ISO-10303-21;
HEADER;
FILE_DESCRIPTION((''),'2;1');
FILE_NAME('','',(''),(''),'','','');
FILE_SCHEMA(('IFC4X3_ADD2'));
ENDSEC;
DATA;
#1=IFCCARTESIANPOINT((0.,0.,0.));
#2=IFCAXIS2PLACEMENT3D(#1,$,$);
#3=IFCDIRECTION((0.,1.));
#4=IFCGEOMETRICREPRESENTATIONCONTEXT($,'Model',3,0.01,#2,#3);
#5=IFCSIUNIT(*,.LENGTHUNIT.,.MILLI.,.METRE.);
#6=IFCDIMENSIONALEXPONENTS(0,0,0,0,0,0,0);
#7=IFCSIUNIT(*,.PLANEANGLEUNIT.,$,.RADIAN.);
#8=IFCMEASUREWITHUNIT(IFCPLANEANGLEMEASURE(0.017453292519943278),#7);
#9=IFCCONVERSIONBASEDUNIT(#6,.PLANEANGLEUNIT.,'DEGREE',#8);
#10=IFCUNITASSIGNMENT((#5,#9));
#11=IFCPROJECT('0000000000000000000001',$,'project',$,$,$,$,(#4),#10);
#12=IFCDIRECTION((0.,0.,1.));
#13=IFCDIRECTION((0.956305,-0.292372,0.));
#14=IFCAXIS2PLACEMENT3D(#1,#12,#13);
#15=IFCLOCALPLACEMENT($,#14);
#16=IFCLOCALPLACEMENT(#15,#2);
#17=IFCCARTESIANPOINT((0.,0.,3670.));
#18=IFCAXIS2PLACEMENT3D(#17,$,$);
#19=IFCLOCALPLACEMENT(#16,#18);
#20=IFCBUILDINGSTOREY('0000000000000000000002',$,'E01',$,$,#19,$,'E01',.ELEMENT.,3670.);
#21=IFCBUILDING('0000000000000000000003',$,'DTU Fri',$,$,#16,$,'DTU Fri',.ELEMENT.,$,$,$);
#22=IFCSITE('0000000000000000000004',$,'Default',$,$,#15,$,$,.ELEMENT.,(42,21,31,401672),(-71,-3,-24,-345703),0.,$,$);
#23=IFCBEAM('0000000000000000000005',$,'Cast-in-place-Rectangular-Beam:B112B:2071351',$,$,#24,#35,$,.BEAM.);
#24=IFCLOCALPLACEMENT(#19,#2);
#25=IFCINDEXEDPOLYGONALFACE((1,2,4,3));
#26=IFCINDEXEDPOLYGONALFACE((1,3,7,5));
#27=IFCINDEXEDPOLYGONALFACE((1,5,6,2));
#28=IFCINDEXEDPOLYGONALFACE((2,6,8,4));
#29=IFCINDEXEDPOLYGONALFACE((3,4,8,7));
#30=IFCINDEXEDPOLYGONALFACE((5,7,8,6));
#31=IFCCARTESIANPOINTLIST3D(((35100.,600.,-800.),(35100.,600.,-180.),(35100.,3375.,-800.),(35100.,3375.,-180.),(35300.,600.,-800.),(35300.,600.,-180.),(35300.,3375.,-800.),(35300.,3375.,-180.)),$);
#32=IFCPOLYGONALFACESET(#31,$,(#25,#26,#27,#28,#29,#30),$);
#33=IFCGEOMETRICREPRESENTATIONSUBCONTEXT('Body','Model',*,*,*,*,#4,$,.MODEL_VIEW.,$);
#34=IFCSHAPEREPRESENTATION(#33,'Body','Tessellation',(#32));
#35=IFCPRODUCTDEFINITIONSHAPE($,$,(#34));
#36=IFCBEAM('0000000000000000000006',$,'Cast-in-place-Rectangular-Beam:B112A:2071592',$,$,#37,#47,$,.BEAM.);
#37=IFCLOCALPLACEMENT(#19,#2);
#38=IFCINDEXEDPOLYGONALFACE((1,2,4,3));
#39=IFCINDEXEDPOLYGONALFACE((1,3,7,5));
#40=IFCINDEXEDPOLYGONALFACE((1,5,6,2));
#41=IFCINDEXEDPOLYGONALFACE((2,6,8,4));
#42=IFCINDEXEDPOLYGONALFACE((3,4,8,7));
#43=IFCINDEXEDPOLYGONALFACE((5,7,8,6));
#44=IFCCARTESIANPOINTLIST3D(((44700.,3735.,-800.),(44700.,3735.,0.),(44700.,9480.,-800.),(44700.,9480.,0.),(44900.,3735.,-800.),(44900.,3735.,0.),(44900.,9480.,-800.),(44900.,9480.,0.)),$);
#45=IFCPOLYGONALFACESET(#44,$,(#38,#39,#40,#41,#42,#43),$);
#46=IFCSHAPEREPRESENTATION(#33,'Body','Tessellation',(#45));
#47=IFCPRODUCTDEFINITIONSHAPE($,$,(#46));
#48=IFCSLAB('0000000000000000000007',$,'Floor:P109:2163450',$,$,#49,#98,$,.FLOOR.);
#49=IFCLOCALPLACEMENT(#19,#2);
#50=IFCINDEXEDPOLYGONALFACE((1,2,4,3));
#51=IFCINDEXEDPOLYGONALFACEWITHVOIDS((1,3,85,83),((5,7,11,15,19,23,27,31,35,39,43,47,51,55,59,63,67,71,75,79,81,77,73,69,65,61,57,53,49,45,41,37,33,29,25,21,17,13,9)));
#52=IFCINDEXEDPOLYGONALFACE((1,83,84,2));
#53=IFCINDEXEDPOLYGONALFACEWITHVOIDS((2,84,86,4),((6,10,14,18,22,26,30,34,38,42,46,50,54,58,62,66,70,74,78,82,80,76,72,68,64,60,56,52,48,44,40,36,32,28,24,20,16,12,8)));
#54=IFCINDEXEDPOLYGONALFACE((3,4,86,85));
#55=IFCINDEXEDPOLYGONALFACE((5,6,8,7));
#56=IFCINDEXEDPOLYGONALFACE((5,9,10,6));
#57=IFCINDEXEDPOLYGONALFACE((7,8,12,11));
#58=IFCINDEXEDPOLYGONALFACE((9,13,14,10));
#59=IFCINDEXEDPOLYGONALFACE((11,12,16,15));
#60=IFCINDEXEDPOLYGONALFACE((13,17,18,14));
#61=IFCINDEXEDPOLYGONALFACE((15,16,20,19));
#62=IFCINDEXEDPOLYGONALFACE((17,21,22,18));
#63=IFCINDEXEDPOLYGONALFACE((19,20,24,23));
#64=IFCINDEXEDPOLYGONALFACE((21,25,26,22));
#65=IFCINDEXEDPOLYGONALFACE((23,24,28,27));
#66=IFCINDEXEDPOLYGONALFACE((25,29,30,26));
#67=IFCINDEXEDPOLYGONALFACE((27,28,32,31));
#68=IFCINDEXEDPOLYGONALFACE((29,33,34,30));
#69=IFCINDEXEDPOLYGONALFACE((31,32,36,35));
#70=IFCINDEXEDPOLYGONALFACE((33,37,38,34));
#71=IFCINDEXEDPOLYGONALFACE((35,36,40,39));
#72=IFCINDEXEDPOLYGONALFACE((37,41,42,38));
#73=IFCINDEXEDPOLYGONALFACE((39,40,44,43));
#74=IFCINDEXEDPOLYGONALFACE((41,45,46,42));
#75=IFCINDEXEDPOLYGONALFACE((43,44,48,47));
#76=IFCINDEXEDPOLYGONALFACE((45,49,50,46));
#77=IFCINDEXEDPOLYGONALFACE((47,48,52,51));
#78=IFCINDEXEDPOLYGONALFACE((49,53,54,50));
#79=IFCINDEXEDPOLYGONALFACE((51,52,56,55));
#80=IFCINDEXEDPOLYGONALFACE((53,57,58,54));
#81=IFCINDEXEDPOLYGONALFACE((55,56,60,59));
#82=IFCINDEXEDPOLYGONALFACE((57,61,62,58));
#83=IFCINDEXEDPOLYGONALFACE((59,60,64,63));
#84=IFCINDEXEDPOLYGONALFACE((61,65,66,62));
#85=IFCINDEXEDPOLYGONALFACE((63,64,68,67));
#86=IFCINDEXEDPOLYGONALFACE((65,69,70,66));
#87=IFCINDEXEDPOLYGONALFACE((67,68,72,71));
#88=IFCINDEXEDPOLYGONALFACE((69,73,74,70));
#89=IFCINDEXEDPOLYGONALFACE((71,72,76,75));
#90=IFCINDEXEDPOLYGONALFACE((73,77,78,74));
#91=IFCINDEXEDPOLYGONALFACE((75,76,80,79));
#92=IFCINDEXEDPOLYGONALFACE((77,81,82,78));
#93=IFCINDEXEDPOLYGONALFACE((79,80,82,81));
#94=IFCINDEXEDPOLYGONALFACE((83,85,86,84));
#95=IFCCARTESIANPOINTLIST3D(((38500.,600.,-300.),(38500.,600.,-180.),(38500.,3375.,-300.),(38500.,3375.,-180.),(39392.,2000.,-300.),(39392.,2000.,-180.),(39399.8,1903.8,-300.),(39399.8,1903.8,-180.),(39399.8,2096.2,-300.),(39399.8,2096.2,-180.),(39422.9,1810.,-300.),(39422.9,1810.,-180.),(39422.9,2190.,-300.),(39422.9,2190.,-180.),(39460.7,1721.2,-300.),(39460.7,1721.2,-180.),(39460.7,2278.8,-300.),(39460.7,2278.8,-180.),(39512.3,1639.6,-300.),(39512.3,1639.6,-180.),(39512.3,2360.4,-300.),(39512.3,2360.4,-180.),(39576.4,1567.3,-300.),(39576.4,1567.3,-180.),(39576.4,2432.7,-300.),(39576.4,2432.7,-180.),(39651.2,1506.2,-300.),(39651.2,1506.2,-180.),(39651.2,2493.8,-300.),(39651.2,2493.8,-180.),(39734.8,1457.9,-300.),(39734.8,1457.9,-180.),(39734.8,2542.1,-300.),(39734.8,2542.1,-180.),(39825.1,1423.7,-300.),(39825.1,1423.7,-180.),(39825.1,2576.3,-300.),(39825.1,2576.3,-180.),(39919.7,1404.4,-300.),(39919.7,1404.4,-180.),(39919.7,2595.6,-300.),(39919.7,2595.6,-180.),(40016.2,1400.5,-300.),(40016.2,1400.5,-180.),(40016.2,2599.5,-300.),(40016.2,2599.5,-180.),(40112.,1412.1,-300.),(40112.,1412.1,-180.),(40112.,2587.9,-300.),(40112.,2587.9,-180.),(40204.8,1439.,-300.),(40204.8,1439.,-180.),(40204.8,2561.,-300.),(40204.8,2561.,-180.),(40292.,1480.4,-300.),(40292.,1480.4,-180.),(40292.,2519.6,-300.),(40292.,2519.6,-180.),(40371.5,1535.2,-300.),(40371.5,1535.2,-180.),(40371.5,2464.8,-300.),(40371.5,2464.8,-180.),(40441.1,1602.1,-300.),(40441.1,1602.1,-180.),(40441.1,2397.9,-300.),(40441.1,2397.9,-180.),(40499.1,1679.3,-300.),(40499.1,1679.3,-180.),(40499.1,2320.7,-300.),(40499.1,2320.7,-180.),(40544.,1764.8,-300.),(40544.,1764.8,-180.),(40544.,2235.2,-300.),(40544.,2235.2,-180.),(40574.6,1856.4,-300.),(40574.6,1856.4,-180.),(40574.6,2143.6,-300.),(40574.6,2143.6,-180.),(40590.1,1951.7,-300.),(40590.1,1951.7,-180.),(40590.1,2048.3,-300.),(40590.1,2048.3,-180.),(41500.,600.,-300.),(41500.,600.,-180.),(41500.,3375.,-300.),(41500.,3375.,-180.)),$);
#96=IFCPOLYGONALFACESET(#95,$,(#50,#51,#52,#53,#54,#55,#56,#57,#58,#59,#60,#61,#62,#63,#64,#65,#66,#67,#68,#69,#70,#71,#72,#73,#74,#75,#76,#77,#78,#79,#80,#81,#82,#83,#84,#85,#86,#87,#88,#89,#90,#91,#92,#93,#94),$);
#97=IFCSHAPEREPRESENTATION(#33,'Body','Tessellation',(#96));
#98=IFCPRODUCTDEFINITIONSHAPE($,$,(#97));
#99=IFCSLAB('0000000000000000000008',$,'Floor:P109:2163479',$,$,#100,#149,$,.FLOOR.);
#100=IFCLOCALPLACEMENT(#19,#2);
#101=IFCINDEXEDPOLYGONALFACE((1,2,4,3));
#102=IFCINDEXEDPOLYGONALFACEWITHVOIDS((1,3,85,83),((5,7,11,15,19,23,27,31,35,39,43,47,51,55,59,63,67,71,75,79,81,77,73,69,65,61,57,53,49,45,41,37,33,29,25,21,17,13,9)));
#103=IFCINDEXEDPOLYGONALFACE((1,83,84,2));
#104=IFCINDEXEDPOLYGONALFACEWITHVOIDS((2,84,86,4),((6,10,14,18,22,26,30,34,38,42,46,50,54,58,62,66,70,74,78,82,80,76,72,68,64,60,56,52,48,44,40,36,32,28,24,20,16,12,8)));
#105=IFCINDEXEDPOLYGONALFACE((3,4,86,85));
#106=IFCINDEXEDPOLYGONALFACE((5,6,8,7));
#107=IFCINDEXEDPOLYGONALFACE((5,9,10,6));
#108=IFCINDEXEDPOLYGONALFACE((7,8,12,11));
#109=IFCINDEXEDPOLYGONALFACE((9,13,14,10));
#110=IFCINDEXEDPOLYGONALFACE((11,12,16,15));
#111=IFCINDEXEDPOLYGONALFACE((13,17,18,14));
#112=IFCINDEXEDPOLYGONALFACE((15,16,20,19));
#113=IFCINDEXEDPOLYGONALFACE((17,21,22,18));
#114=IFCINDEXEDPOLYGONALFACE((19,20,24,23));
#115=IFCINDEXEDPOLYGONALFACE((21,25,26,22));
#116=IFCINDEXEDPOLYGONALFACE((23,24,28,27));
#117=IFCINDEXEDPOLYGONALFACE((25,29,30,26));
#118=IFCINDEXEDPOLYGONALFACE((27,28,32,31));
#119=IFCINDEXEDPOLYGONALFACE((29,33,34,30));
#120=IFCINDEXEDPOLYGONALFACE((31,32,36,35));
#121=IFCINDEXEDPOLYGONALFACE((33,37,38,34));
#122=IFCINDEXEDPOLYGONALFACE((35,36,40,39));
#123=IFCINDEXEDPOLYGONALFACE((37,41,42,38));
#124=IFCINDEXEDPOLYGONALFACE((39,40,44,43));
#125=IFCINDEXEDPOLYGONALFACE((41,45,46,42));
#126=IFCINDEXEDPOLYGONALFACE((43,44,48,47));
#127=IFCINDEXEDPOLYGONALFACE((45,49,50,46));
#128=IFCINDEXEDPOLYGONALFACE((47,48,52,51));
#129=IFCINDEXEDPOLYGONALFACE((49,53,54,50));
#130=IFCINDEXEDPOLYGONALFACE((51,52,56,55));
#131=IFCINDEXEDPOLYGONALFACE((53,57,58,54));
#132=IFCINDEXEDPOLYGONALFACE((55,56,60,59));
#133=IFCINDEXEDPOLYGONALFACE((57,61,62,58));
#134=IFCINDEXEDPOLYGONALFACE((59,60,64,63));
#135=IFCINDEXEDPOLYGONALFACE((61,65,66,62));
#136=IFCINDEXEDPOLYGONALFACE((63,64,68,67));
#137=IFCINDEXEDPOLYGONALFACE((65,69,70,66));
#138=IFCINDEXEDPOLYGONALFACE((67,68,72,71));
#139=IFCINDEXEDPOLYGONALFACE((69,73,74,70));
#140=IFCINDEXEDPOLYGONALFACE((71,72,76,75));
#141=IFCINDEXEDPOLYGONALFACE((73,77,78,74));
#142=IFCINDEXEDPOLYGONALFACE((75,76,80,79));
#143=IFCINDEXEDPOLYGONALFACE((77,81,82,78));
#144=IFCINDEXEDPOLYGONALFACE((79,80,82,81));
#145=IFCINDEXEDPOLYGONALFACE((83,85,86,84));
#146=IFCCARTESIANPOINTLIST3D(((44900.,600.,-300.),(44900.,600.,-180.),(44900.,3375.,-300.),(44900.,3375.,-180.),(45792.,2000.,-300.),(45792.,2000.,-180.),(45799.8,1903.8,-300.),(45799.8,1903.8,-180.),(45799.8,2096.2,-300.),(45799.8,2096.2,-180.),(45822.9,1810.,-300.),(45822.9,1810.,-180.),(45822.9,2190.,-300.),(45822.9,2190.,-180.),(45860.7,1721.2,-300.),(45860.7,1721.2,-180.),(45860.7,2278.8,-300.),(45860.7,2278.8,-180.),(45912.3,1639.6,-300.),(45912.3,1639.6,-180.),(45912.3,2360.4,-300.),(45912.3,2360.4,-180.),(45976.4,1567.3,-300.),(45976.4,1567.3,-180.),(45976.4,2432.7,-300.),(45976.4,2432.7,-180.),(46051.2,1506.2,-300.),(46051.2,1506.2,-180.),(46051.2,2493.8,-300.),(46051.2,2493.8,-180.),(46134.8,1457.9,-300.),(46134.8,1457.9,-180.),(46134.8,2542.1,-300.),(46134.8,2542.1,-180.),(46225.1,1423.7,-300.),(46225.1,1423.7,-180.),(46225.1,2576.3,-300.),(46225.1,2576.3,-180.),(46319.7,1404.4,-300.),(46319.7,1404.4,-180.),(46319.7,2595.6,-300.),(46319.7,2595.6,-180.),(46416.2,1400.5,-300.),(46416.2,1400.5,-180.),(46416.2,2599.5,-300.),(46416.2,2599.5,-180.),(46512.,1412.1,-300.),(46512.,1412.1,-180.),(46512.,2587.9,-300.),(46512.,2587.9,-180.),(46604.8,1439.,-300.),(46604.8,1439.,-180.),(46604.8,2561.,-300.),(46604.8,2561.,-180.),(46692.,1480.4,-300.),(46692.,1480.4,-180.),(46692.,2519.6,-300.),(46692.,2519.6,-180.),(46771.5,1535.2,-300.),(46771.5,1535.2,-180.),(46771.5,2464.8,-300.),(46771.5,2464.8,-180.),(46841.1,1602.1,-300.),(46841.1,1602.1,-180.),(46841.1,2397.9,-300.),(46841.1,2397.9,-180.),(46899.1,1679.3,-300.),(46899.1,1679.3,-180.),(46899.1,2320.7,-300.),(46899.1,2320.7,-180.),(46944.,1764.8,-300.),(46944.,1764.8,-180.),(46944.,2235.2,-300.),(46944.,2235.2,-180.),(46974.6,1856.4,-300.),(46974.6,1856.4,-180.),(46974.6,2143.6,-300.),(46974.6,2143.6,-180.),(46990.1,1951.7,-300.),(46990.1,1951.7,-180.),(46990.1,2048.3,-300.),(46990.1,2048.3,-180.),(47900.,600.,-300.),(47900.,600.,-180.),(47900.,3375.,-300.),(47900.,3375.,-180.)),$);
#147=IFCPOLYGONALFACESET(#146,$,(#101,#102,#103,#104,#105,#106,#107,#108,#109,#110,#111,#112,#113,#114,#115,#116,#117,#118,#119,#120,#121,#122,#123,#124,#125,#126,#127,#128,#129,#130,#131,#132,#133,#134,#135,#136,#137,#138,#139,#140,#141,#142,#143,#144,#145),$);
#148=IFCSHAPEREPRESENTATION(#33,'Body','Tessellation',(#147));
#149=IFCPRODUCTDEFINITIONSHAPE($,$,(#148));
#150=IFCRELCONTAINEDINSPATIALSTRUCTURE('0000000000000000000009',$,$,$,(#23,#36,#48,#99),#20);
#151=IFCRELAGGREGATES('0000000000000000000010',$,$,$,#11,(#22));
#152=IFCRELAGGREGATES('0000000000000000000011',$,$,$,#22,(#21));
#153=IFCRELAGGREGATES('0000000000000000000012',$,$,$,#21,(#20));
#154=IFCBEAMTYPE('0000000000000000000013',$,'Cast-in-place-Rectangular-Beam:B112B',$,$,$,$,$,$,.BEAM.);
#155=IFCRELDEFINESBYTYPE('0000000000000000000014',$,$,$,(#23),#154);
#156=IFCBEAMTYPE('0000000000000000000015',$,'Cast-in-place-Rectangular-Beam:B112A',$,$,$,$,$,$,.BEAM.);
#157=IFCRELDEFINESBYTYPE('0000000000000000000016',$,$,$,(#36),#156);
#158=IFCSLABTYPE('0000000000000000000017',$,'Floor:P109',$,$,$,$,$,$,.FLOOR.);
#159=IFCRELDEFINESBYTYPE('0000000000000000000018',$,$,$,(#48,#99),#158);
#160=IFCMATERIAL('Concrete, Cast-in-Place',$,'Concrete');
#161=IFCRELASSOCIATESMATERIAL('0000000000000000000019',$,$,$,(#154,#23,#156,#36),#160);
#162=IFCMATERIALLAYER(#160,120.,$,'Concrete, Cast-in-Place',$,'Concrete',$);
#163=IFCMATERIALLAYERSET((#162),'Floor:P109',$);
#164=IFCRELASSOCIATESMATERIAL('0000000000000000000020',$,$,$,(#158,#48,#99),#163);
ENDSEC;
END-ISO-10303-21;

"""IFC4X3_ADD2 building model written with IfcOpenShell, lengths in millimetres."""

from ifc_helpers import new_model, entity, si_unit, converted_unit, direction, frame, frame_2d, origin, origin_2d_with_axis, place, context, subcontext, project, spatial, rectangle, circle, extrude, source, transform, mapped, material, layer, layer_set, layer_usage, material_profile, profile_set, profile_usage, type_object, type_shapes, element, save


model = new_model("IFC4X3_ADD2")

# Units and contexts
model_context = context("Model", 3, precision=0.01, world=origin(), true_north=direction((0.0, 1.0)))
body_context = subcontext(model_context, "Body", "Model", "MODEL_VIEW")
ifc_project = project(units=[si_unit("LENGTHUNIT", "METRE", prefix="MILLI"), converted_unit("PLANEANGLEUNIT", "DEGREE", entity("IfcPlaneAngleMeasure", 0.017453292519943278), si_unit("PLANEANGLEUNIT", "RADIAN"), dimensions=[0, 0, 0, 0, 0, 0, 0])], contexts=[model_context])

# Site, building, storey
site_placement = place(None, frame((0.0, 0.0, 0.0), z_axis=(0.0, 0.0, 1.0), x_axis=(0.956305, -0.292372, 0.0)))
site = spatial("IfcSite", under=ifc_project, at=site_placement, Name="Default", CompositionType="ELEMENT", RefLatitude=(42, 21, 31, 401672), RefLongitude=(-71, -3, -24, -345703), RefElevation=0.0)
building_placement = place(site_placement, origin())
building = spatial("IfcBuilding", under=site, at=building_placement, Name="DTU Fri", LongName="DTU Fri", CompositionType="ELEMENT")
storey_placement = place(building_placement, frame((0.0, 0.0, 3670.0)))
storey = spatial("IfcBuildingStorey", under=building, at=storey_placement, Name="E01", LongName="E01", CompositionType="ELEMENT", Elevation=3670.0)

# Beams
ifc_material_1 = material(Name="Concrete, Cast-in-Place", Category="Concrete")
ifc_material_profile_1 = material_profile(ifc_material_1, rectangle(XDim=800.0, YDim=200.0, at=origin_2d_with_axis()), Name="B112A")
ifc_profile_set_1 = profile_set([ifc_material_profile_1], Name="B112A")
ifc_profile_usage_1 = profile_usage(ifc_profile_set_1, cardinal=8)
ifc_material_profile_2 = material_profile(ifc_material_1, rectangle(XDim=620.0, YDim=200.0, at=origin_2d_with_axis()), Name="B112B")
ifc_profile_set_2 = profile_set([ifc_material_profile_2], Name="B112B")
ifc_profile_usage_2 = profile_usage(ifc_profile_set_2, cardinal=8)
beam_type_1 = type_object("IfcBeamType", Name="Cast-in-place-Rectangular-Beam:B112B", PredefinedType="BEAM", material=ifc_profile_set_2)
shared_shape_1 = source(origin(), body_context, "Body", "SweptSolid", [
    extrude(rectangle(XDim=620.0, YDim=200.0, at=origin_2d_with_axis()), frame((-1347.5, 0.0, 0.0), z_axis=(1.0, 0.0, 0.0), x_axis=(0.0, 0.0, -1.0)), (0.0, 0.0, 1.0), 2775.0),
])
type_shapes(beam_type_1, [shared_shape_1])
for number, where, z_axis, x_axis, name in (
    (1, (35200.0, 2027.5, -490.0), (0.0, 0.0, 1.0), (0.0, -1.0, 0.0), "Cast-in-place-Rectangular-Beam:B112B:2071351"),
):
    element("IfcBeam", number, at=place(storey_placement, frame(where, z_axis=z_axis, x_axis=x_axis)), inside=storey, type_object=beam_type_1, material=ifc_profile_usage_2, Name=name, PredefinedType="BEAM", context=body_context, shape_type="MappedRepresentation", body=[
        mapped(shared_shape_1, transform((0.0, 0.0, 0.0), scale=1.0)),
    ])
beam_type_2 = type_object("IfcBeamType", Name="Cast-in-place-Rectangular-Beam:B112A", PredefinedType="BEAM", material=ifc_profile_set_1)
shared_shape_2 = source(origin(), body_context, "Body", "SweptSolid", [
    extrude(rectangle(XDim=800.0, YDim=200.0, at=origin_2d_with_axis()), frame((-2902.5, 0.0, 0.0), z_axis=(1.0, 0.0, 0.0), x_axis=(0.0, 0.0, -1.0)), (0.0, 0.0, 1.0), 5745.0),
])
type_shapes(beam_type_2, [shared_shape_2])
beam_placement = place(storey_placement, frame((44800.0, 6577.5, -400.0), z_axis=(0.0, 0.0, 1.0), x_axis=(0.0, -1.0, 0.0)))
element("IfcBeam", 2, at=beam_placement, inside=storey, type_object=beam_type_2, material=ifc_profile_usage_1, Name="Cast-in-place-Rectangular-Beam:B112A:2071592", PredefinedType="BEAM", context=body_context, shape_type="MappedRepresentation", body=[
    mapped(shared_shape_2, transform((0.0, 0.0, 0.0), scale=1.0)),
])

# Slabs, openings
ifc_layer = layer(ifc_material_1, 120.0, Name="Concrete, Cast-in-Place", Category="Concrete")
ifc_layer_set = layer_set([ifc_layer], Name="Floor:P109")
ifc_layer_usage_1 = layer_usage(ifc_layer_set, "AXIS3", "POSITIVE", 0.0)
slab_type = type_object("IfcSlabType", Name="Floor:P109", PredefinedType="FLOOR", material=ifc_layer_set)
slab_1_placement = place(storey_placement, frame((38500.0, 600.0, -300.0)))
slab_1 = element("IfcSlab", 3, at=slab_1_placement, inside=storey, type_object=slab_type, material=ifc_layer_usage_1, Name="Floor:P109:2163450", PredefinedType="FLOOR", context=body_context, shape_type="SweptSolid", body=[
    extrude(rectangle(XDim=2775.0, YDim=3000.0, at=frame_2d((0.0, 0.0), x_axis=(0.0, -1.0))), frame((1500.0, 1387.5, 120.0), z_axis=(0.0, 0.0, -1.0), x_axis=(-1.0, 0.0, 0.0)), (0.0, 0.0, 1.0), 120.0),
])
opening_1_placement = place(slab_1_placement, origin())
element("IfcOpeningElement", 4, at=opening_1_placement, cuts=slab_1, PredefinedType="OPENING", context=body_context, shape_type="SweptSolid", body=[
    extrude(circle(Radius=600.0, at=frame_2d((8.0, 12.5), x_axis=(1.0, 0.0))), frame((1500.0, 1387.5, 120.0), z_axis=(0.0, 0.0, -1.0), x_axis=(-1.0, 0.0, 0.0)), (0.0, 0.0, 1.0), 120.0),
])
ifc_layer_usage_2 = layer_usage(ifc_layer_set, "AXIS3", "POSITIVE", 0.0)
slab_2_placement = place(storey_placement, frame((44900.0, 600.0, -300.0)))
slab_2 = element("IfcSlab", 5, at=slab_2_placement, inside=storey, type_object=slab_type, material=ifc_layer_usage_2, Name="Floor:P109:2163479", PredefinedType="FLOOR", context=body_context, shape_type="SweptSolid", body=[
    extrude(rectangle(XDim=2775.0, YDim=3000.0, at=frame_2d((0.0, 0.0), x_axis=(0.0, -1.0))), frame((1500.0, 1387.5, 120.0), z_axis=(0.0, 0.0, -1.0), x_axis=(-1.0, 0.0, 0.0)), (0.0, 0.0, 1.0), 120.0),
])
opening_2_placement = place(slab_2_placement, origin())
element("IfcOpeningElement", 6, at=opening_2_placement, cuts=slab_2, PredefinedType="OPENING", context=body_context, shape_type="SweptSolid", body=[
    extrude(circle(Radius=600.0, at=frame_2d((8.0, 12.5), x_axis=(1.0, 0.0))), frame((1500.0, 1387.5, 120.0), z_axis=(0.0, 0.0, -1.0), x_axis=(-1.0, 0.0, 0.0)), (0.0, 0.0, 1.0), 120.0),
])

save(model, "model.ifc")
